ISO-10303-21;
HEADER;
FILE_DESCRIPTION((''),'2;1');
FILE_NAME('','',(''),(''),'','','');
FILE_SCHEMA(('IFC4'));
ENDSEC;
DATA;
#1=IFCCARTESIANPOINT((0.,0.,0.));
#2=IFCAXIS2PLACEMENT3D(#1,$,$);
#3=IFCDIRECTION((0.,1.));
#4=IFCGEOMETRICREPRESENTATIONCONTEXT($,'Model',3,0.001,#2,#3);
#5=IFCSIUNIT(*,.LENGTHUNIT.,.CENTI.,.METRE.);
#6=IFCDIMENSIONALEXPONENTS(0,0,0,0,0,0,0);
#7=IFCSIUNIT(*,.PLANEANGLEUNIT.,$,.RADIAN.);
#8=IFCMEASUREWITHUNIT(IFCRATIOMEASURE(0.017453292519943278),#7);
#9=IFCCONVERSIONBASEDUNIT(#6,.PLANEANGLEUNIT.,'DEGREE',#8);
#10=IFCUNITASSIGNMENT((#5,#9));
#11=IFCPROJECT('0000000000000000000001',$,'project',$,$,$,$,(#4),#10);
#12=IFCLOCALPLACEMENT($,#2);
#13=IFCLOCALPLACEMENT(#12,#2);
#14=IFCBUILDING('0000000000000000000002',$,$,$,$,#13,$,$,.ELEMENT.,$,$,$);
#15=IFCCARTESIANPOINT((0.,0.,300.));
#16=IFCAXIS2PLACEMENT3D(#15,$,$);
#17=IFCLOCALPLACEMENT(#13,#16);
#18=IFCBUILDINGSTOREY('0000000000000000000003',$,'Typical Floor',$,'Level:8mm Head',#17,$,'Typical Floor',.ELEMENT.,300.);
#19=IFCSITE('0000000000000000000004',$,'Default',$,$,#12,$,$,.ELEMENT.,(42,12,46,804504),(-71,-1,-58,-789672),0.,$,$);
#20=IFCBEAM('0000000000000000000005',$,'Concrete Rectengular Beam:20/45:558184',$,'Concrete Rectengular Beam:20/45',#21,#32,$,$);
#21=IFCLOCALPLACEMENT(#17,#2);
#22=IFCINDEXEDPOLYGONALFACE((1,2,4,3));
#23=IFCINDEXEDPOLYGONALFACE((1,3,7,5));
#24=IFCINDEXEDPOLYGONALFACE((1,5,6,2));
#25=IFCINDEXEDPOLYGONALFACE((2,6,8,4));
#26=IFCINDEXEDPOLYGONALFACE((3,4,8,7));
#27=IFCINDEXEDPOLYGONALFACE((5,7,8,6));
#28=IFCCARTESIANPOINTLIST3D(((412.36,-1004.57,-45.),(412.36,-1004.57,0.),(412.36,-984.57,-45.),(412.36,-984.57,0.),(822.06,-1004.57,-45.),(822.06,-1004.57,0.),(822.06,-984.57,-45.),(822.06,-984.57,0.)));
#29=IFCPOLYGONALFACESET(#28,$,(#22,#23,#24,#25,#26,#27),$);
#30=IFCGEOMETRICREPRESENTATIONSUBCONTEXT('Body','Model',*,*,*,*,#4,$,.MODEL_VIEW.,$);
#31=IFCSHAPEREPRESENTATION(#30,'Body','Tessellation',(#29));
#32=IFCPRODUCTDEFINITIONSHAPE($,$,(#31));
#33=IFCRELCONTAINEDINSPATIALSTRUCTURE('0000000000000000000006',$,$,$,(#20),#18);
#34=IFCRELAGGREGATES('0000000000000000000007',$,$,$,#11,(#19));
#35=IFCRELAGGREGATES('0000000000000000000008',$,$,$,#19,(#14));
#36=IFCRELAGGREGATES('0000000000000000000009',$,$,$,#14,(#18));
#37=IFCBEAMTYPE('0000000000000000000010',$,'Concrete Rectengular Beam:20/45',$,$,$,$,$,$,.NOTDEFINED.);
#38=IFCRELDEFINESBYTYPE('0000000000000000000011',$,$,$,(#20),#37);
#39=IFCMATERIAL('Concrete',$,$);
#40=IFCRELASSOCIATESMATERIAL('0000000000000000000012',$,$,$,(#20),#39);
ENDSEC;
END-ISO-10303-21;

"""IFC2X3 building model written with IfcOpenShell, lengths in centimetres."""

from ifc_helpers import new_model, entity, si_unit, converted_unit, direction, frame, frame_2d, origin, place, context, subcontext, project, spatial, rectangle, extrude, material, type_object, element, save


model = new_model("IFC2X3")

# Units and contexts
model_context = context("Model", 3, precision=0.001, world=origin(), true_north=direction((0.0, 1.0)))
body_context = subcontext(model_context, "Body", "Model", "MODEL_VIEW")
ifc_project = project(units=[si_unit("LENGTHUNIT", "METRE", prefix="CENTI"), converted_unit("PLANEANGLEUNIT", "DEGREE", entity("IfcRatioMeasure", 0.017453292519943278), si_unit("PLANEANGLEUNIT", "RADIAN"), dimensions=[0, 0, 0, 0, 0, 0, 0])], contexts=[model_context])

# Site, building, storey
site_placement = place(None, origin())
site = spatial("IfcSite", under=ifc_project, at=site_placement, Name="Default", CompositionType="ELEMENT", RefLatitude=(42, 12, 46, 804504), RefLongitude=(-71, -1, -58, -789672), RefElevation=0.0)
building_placement = place(site_placement, origin())
building = spatial("IfcBuilding", under=site, at=building_placement, CompositionType="ELEMENT")
storey_placement = place(building_placement, frame((0.0, 0.0, 300.0)))
storey = spatial("IfcBuildingStorey", under=building, at=storey_placement, Name="Typical Floor", ObjectType="Level:8mm Head", LongName="Typical Floor", CompositionType="ELEMENT", Elevation=300.0)

# Beam
ifc_material = material(Name="Concrete")
beam_type_1 = type_object("IfcBeamType", Name="Concrete Rectengular Beam:20/45", PredefinedType="NOTDEFINED")
beam_1_placement = place(storey_placement, frame((832.06, -994.57, 0.0), z_axis=(0.0, 0.0, 1.0), x_axis=(-1.0, 0.0, 0.0)))
element("IfcBeam", 1, at=beam_1_placement, inside=storey, type_object=beam_type_1, material=ifc_material, Name="Concrete Rectengular Beam:20/45:558184", ObjectType="Concrete Rectengular Beam:20/45", context=body_context, shape_type="SweptSolid", body=[
    extrude(rectangle(XDim=45.0, YDim=20.0, at=frame_2d((0.0, 0.0), x_axis=(1.0, 0.0))), frame((10.0, 0.0, -22.5), z_axis=(1.0, 0.0, 0.0), x_axis=(0.0, 0.0, -1.0)), (0.0, 0.0, 1.0), 409.7),
])

save(model, "model.ifc")
